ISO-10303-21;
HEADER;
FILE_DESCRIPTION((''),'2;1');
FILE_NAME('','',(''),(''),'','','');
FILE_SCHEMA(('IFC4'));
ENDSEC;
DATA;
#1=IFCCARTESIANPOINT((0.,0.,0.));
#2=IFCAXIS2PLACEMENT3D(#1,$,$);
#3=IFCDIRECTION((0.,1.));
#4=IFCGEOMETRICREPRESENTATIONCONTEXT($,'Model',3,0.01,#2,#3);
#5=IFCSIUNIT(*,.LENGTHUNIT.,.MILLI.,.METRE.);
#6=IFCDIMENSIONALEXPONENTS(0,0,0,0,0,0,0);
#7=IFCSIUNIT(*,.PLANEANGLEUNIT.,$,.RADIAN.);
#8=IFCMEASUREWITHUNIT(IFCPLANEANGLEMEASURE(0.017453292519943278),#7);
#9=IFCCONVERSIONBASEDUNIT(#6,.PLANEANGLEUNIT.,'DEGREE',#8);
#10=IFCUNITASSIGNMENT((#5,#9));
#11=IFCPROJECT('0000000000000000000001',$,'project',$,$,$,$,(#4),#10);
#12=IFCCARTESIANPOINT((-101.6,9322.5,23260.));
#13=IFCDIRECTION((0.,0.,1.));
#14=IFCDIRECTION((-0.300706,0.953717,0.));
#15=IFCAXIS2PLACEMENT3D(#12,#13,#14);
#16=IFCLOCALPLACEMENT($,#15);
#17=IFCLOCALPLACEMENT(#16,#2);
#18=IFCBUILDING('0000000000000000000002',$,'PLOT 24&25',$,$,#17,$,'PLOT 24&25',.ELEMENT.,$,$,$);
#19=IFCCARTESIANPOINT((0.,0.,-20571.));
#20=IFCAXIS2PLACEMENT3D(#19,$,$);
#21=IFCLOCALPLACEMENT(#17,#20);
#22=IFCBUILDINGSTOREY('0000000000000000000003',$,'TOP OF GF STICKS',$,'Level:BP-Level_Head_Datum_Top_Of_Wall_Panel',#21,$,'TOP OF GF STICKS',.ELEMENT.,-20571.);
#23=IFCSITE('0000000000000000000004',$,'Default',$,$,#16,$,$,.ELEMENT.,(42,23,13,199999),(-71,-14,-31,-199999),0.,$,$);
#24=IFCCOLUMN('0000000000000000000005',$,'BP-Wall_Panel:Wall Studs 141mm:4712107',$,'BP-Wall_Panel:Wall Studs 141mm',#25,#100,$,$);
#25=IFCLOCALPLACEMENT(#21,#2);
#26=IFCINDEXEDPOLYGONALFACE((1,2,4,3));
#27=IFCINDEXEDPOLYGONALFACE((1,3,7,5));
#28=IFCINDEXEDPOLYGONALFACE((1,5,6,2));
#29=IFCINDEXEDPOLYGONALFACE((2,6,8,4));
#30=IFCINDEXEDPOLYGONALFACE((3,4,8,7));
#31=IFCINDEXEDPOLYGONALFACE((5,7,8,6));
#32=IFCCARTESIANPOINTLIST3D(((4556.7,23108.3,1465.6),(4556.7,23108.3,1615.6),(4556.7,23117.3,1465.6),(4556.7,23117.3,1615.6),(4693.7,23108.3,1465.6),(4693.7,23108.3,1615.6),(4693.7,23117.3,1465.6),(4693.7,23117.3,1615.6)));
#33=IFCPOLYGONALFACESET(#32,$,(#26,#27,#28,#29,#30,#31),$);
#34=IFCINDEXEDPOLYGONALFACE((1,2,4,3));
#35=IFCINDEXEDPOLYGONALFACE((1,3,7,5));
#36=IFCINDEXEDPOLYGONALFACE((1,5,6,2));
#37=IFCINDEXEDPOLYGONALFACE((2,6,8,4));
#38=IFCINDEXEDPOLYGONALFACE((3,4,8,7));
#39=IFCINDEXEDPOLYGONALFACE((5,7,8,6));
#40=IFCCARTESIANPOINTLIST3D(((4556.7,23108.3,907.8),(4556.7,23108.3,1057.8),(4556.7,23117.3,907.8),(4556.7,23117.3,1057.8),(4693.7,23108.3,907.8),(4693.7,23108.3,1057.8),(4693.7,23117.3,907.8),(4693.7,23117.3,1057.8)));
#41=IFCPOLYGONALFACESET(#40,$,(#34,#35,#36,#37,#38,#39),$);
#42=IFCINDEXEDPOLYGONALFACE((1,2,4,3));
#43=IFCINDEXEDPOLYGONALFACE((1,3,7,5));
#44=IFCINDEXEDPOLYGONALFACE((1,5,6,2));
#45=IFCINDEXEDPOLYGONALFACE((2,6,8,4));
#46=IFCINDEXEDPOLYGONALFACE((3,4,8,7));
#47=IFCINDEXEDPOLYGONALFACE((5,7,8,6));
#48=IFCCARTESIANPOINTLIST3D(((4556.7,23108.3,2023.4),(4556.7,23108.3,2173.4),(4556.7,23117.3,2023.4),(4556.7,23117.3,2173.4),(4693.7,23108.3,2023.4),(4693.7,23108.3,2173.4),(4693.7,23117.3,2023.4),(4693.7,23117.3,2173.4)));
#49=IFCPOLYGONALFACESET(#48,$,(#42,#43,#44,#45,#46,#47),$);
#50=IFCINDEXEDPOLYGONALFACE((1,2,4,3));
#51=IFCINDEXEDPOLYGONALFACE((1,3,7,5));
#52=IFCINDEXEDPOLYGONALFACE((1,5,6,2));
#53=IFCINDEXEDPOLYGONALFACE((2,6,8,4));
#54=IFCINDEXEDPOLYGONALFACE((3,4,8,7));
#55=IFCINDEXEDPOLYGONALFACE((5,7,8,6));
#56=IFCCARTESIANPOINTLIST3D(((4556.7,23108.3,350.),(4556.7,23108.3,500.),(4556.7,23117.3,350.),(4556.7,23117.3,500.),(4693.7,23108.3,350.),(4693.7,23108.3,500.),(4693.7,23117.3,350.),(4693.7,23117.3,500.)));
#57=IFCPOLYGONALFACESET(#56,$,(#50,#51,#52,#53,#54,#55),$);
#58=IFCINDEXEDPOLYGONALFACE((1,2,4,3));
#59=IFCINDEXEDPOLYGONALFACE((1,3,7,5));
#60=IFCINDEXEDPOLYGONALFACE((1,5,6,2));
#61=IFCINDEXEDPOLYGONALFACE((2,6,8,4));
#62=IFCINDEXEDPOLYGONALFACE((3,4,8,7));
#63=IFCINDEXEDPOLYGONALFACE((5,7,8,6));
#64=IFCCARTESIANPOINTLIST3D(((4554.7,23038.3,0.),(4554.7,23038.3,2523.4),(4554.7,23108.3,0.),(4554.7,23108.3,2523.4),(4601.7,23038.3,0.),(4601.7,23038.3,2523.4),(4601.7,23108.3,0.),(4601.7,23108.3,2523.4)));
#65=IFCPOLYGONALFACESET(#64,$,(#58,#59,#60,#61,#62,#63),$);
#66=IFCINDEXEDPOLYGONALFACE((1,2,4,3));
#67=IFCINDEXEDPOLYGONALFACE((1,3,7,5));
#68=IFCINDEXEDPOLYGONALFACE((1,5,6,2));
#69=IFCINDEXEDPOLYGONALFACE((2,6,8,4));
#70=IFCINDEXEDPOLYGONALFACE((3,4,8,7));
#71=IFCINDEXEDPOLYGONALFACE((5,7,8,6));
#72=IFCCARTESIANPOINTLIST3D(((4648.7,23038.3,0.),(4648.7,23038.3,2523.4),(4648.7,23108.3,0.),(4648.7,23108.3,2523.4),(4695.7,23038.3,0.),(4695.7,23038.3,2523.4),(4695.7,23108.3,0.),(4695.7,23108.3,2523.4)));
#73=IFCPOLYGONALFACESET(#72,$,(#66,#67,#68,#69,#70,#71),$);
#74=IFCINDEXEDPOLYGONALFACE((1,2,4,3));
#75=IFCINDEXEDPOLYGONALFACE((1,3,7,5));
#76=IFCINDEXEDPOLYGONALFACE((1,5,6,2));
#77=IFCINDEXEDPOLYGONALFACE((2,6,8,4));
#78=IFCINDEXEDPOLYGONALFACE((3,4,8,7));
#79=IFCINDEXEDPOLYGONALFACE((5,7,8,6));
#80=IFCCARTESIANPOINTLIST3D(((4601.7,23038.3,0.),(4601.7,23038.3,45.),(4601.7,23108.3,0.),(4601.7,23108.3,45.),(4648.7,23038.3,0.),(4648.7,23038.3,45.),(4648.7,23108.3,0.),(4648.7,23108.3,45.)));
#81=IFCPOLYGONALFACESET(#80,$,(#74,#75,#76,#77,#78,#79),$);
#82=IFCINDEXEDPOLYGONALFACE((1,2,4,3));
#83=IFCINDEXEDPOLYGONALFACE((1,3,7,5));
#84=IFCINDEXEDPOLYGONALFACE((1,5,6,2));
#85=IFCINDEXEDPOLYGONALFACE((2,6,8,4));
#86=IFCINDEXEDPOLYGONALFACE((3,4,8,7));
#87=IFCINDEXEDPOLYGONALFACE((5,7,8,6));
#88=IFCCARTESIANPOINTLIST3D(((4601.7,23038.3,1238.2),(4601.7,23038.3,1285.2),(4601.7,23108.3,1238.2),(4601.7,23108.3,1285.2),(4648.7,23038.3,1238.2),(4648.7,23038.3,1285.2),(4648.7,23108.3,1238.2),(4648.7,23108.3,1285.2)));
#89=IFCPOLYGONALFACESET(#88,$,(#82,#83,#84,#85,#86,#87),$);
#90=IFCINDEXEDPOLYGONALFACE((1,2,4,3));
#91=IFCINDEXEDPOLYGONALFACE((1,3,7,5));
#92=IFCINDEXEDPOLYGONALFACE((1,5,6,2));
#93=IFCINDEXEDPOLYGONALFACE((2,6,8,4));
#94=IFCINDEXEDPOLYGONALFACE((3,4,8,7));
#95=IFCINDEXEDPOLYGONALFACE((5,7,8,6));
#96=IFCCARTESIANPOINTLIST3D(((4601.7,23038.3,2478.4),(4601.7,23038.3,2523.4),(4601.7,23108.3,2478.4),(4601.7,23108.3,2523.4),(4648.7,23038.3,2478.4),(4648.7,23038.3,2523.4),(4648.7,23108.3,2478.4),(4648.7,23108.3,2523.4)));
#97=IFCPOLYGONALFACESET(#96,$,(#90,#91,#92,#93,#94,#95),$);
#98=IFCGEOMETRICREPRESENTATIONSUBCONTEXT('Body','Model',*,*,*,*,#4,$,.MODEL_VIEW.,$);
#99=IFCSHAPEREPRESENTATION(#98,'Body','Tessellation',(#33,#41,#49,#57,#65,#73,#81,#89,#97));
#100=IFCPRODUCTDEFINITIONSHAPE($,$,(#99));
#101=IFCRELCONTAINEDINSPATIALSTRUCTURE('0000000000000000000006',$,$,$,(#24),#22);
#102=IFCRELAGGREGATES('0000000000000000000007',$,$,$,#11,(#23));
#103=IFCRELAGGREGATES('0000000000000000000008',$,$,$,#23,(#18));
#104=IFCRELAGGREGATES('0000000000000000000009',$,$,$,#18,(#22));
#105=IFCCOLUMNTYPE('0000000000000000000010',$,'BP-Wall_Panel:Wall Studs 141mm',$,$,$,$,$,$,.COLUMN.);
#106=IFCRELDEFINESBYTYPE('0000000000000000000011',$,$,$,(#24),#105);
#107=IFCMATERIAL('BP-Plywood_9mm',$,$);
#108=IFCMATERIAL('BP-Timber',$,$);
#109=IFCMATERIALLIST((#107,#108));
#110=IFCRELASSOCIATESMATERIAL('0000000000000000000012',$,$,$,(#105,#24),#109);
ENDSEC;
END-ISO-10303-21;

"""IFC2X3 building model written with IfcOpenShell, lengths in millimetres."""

from ifc_helpers import new_model, entity, si_unit, converted_unit, direction, frame, frame_2d, origin, origin_2d_with_axis, place, context, subcontext, project, spatial, rectangle, extrude, source, transform, mapped, material, material_list, type_object, type_shapes, element, save


model = new_model("IFC2X3")

# Units and contexts
model_context = context("Model", 3, precision=0.01, world=origin(), true_north=direction((0.0, 1.0)))
body_context = subcontext(model_context, "Body", "Model", "MODEL_VIEW")
ifc_project = project(units=[si_unit("LENGTHUNIT", "METRE", prefix="MILLI"), converted_unit("PLANEANGLEUNIT", "DEGREE", entity("IfcPlaneAngleMeasure", 0.017453292519943278), si_unit("PLANEANGLEUNIT", "RADIAN"), dimensions=[0, 0, 0, 0, 0, 0, 0])], contexts=[model_context])

# Site, building, storey
site_placement = place(None, frame((-101.6, 9322.5, 23260.0), z_axis=(0.0, 0.0, 1.0), x_axis=(-0.300706, 0.953717, 0.0)))
site = spatial("IfcSite", under=ifc_project, at=site_placement, Name="Default", CompositionType="ELEMENT", RefLatitude=(42, 23, 13, 199999), RefLongitude=(-71, -14, -31, -199999), RefElevation=0.0)
building_placement = place(site_placement, origin())
building = spatial("IfcBuilding", under=site, at=building_placement, Name="PLOT 24&25", LongName="PLOT 24&25", CompositionType="ELEMENT")
storey_placement = place(building_placement, frame((0.0, 0.0, -20571.0)))
storey = spatial("IfcBuildingStorey", under=building, at=storey_placement, Name="TOP OF GF STICKS", ObjectType="Level:BP-Level_Head_Datum_Top_Of_Wall_Panel", LongName="TOP OF GF STICKS", CompositionType="ELEMENT", Elevation=-20571.0)

# Column
ifc_material_1 = material(Name="BP-Plywood_9mm")
ifc_material_2 = material(Name="BP-Timber")
ifc_material_list = material_list([ifc_material_1, ifc_material_2])
column_type_1 = type_object("IfcColumnType", Name="BP-Wall_Panel:Wall Studs 141mm", PredefinedType="COLUMN", material=ifc_material_list)
shared_shape_1 = source(origin(), body_context, "Body", "SweptSolid", [
    extrude(rectangle(XDim=9.0, YDim=137.0, at=origin_2d_with_axis()), frame((39.5, 0.0, -19105.4)), (0.0, 0.0, 1.0), 150.0),
    extrude(rectangle(XDim=9.0, YDim=137.0, at=origin_2d_with_axis()), frame((39.5, 0.0, -19663.2)), (0.0, 0.0, 1.0), 150.0),
    extrude(rectangle(XDim=9.0, YDim=137.0, at=frame_2d((0.0, 0.0), x_axis=(1.0, 0.0))), frame((39.5, 0.0, -18547.6)), (0.0, 0.0, 1.0), 150.0),
    extrude(rectangle(XDim=9.0, YDim=137.0, at=origin_2d_with_axis()), frame((39.5, 0.0, -20221.0)), (0.0, 0.0, 1.0), 150.0),
    extrude(rectangle(XDim=47.0, YDim=70.0, at=origin_2d_with_axis()), frame((0.0, 47.0, -20571.0), z_axis=(0.0, 0.0, 1.0), x_axis=(0.0, 1.0, 0.0)), (0.0, 0.0, 1.0), 2523.4),
    extrude(rectangle(XDim=47.0, YDim=70.0, at=origin_2d_with_axis()), frame((0.0, -47.0, -20571.0), z_axis=(0.0, 0.0, 1.0), x_axis=(0.0, 1.0, 0.0)), (0.0, 0.0, 1.0), 2523.4),
    extrude(rectangle(XDim=70.0, YDim=47.0, at=origin_2d_with_axis()), frame((0.0, 0.0, -20571.0)), (0.0, 0.0, 1.0), 45.0),
    extrude(rectangle(XDim=70.0, YDim=47.0, at=origin_2d_with_axis()), frame((0.0, 0.0, -19332.8)), (0.0, 0.0, 1.0), 47.0),
    extrude(rectangle(XDim=70.0, YDim=47.0, at=origin_2d_with_axis()), frame((0.0, 0.0, -18092.6)), (0.0, 0.0, 1.0), 45.0),
])
type_shapes(column_type_1, [shared_shape_1])
for number, where, z_axis, x_axis, name in (
    (1, (4625.2, 23073.3, 20571.0), (0.0, 0.0, 1.0), (0.0, 1.0, 0.0), "BP-Wall_Panel:Wall Studs 141mm:4712107"),
):
    element("IfcColumn", number, at=place(storey_placement, frame(where, z_axis=z_axis, x_axis=x_axis)), inside=storey, type_object=column_type_1, material=ifc_material_list, Name=name, ObjectType="BP-Wall_Panel:Wall Studs 141mm", context=body_context, shape_type="MappedRepresentation", body=[
        mapped(shared_shape_1, transform((0.0, 0.0, 0.0), scale=1.0)),
    ])

save(model, "model.ifc")
